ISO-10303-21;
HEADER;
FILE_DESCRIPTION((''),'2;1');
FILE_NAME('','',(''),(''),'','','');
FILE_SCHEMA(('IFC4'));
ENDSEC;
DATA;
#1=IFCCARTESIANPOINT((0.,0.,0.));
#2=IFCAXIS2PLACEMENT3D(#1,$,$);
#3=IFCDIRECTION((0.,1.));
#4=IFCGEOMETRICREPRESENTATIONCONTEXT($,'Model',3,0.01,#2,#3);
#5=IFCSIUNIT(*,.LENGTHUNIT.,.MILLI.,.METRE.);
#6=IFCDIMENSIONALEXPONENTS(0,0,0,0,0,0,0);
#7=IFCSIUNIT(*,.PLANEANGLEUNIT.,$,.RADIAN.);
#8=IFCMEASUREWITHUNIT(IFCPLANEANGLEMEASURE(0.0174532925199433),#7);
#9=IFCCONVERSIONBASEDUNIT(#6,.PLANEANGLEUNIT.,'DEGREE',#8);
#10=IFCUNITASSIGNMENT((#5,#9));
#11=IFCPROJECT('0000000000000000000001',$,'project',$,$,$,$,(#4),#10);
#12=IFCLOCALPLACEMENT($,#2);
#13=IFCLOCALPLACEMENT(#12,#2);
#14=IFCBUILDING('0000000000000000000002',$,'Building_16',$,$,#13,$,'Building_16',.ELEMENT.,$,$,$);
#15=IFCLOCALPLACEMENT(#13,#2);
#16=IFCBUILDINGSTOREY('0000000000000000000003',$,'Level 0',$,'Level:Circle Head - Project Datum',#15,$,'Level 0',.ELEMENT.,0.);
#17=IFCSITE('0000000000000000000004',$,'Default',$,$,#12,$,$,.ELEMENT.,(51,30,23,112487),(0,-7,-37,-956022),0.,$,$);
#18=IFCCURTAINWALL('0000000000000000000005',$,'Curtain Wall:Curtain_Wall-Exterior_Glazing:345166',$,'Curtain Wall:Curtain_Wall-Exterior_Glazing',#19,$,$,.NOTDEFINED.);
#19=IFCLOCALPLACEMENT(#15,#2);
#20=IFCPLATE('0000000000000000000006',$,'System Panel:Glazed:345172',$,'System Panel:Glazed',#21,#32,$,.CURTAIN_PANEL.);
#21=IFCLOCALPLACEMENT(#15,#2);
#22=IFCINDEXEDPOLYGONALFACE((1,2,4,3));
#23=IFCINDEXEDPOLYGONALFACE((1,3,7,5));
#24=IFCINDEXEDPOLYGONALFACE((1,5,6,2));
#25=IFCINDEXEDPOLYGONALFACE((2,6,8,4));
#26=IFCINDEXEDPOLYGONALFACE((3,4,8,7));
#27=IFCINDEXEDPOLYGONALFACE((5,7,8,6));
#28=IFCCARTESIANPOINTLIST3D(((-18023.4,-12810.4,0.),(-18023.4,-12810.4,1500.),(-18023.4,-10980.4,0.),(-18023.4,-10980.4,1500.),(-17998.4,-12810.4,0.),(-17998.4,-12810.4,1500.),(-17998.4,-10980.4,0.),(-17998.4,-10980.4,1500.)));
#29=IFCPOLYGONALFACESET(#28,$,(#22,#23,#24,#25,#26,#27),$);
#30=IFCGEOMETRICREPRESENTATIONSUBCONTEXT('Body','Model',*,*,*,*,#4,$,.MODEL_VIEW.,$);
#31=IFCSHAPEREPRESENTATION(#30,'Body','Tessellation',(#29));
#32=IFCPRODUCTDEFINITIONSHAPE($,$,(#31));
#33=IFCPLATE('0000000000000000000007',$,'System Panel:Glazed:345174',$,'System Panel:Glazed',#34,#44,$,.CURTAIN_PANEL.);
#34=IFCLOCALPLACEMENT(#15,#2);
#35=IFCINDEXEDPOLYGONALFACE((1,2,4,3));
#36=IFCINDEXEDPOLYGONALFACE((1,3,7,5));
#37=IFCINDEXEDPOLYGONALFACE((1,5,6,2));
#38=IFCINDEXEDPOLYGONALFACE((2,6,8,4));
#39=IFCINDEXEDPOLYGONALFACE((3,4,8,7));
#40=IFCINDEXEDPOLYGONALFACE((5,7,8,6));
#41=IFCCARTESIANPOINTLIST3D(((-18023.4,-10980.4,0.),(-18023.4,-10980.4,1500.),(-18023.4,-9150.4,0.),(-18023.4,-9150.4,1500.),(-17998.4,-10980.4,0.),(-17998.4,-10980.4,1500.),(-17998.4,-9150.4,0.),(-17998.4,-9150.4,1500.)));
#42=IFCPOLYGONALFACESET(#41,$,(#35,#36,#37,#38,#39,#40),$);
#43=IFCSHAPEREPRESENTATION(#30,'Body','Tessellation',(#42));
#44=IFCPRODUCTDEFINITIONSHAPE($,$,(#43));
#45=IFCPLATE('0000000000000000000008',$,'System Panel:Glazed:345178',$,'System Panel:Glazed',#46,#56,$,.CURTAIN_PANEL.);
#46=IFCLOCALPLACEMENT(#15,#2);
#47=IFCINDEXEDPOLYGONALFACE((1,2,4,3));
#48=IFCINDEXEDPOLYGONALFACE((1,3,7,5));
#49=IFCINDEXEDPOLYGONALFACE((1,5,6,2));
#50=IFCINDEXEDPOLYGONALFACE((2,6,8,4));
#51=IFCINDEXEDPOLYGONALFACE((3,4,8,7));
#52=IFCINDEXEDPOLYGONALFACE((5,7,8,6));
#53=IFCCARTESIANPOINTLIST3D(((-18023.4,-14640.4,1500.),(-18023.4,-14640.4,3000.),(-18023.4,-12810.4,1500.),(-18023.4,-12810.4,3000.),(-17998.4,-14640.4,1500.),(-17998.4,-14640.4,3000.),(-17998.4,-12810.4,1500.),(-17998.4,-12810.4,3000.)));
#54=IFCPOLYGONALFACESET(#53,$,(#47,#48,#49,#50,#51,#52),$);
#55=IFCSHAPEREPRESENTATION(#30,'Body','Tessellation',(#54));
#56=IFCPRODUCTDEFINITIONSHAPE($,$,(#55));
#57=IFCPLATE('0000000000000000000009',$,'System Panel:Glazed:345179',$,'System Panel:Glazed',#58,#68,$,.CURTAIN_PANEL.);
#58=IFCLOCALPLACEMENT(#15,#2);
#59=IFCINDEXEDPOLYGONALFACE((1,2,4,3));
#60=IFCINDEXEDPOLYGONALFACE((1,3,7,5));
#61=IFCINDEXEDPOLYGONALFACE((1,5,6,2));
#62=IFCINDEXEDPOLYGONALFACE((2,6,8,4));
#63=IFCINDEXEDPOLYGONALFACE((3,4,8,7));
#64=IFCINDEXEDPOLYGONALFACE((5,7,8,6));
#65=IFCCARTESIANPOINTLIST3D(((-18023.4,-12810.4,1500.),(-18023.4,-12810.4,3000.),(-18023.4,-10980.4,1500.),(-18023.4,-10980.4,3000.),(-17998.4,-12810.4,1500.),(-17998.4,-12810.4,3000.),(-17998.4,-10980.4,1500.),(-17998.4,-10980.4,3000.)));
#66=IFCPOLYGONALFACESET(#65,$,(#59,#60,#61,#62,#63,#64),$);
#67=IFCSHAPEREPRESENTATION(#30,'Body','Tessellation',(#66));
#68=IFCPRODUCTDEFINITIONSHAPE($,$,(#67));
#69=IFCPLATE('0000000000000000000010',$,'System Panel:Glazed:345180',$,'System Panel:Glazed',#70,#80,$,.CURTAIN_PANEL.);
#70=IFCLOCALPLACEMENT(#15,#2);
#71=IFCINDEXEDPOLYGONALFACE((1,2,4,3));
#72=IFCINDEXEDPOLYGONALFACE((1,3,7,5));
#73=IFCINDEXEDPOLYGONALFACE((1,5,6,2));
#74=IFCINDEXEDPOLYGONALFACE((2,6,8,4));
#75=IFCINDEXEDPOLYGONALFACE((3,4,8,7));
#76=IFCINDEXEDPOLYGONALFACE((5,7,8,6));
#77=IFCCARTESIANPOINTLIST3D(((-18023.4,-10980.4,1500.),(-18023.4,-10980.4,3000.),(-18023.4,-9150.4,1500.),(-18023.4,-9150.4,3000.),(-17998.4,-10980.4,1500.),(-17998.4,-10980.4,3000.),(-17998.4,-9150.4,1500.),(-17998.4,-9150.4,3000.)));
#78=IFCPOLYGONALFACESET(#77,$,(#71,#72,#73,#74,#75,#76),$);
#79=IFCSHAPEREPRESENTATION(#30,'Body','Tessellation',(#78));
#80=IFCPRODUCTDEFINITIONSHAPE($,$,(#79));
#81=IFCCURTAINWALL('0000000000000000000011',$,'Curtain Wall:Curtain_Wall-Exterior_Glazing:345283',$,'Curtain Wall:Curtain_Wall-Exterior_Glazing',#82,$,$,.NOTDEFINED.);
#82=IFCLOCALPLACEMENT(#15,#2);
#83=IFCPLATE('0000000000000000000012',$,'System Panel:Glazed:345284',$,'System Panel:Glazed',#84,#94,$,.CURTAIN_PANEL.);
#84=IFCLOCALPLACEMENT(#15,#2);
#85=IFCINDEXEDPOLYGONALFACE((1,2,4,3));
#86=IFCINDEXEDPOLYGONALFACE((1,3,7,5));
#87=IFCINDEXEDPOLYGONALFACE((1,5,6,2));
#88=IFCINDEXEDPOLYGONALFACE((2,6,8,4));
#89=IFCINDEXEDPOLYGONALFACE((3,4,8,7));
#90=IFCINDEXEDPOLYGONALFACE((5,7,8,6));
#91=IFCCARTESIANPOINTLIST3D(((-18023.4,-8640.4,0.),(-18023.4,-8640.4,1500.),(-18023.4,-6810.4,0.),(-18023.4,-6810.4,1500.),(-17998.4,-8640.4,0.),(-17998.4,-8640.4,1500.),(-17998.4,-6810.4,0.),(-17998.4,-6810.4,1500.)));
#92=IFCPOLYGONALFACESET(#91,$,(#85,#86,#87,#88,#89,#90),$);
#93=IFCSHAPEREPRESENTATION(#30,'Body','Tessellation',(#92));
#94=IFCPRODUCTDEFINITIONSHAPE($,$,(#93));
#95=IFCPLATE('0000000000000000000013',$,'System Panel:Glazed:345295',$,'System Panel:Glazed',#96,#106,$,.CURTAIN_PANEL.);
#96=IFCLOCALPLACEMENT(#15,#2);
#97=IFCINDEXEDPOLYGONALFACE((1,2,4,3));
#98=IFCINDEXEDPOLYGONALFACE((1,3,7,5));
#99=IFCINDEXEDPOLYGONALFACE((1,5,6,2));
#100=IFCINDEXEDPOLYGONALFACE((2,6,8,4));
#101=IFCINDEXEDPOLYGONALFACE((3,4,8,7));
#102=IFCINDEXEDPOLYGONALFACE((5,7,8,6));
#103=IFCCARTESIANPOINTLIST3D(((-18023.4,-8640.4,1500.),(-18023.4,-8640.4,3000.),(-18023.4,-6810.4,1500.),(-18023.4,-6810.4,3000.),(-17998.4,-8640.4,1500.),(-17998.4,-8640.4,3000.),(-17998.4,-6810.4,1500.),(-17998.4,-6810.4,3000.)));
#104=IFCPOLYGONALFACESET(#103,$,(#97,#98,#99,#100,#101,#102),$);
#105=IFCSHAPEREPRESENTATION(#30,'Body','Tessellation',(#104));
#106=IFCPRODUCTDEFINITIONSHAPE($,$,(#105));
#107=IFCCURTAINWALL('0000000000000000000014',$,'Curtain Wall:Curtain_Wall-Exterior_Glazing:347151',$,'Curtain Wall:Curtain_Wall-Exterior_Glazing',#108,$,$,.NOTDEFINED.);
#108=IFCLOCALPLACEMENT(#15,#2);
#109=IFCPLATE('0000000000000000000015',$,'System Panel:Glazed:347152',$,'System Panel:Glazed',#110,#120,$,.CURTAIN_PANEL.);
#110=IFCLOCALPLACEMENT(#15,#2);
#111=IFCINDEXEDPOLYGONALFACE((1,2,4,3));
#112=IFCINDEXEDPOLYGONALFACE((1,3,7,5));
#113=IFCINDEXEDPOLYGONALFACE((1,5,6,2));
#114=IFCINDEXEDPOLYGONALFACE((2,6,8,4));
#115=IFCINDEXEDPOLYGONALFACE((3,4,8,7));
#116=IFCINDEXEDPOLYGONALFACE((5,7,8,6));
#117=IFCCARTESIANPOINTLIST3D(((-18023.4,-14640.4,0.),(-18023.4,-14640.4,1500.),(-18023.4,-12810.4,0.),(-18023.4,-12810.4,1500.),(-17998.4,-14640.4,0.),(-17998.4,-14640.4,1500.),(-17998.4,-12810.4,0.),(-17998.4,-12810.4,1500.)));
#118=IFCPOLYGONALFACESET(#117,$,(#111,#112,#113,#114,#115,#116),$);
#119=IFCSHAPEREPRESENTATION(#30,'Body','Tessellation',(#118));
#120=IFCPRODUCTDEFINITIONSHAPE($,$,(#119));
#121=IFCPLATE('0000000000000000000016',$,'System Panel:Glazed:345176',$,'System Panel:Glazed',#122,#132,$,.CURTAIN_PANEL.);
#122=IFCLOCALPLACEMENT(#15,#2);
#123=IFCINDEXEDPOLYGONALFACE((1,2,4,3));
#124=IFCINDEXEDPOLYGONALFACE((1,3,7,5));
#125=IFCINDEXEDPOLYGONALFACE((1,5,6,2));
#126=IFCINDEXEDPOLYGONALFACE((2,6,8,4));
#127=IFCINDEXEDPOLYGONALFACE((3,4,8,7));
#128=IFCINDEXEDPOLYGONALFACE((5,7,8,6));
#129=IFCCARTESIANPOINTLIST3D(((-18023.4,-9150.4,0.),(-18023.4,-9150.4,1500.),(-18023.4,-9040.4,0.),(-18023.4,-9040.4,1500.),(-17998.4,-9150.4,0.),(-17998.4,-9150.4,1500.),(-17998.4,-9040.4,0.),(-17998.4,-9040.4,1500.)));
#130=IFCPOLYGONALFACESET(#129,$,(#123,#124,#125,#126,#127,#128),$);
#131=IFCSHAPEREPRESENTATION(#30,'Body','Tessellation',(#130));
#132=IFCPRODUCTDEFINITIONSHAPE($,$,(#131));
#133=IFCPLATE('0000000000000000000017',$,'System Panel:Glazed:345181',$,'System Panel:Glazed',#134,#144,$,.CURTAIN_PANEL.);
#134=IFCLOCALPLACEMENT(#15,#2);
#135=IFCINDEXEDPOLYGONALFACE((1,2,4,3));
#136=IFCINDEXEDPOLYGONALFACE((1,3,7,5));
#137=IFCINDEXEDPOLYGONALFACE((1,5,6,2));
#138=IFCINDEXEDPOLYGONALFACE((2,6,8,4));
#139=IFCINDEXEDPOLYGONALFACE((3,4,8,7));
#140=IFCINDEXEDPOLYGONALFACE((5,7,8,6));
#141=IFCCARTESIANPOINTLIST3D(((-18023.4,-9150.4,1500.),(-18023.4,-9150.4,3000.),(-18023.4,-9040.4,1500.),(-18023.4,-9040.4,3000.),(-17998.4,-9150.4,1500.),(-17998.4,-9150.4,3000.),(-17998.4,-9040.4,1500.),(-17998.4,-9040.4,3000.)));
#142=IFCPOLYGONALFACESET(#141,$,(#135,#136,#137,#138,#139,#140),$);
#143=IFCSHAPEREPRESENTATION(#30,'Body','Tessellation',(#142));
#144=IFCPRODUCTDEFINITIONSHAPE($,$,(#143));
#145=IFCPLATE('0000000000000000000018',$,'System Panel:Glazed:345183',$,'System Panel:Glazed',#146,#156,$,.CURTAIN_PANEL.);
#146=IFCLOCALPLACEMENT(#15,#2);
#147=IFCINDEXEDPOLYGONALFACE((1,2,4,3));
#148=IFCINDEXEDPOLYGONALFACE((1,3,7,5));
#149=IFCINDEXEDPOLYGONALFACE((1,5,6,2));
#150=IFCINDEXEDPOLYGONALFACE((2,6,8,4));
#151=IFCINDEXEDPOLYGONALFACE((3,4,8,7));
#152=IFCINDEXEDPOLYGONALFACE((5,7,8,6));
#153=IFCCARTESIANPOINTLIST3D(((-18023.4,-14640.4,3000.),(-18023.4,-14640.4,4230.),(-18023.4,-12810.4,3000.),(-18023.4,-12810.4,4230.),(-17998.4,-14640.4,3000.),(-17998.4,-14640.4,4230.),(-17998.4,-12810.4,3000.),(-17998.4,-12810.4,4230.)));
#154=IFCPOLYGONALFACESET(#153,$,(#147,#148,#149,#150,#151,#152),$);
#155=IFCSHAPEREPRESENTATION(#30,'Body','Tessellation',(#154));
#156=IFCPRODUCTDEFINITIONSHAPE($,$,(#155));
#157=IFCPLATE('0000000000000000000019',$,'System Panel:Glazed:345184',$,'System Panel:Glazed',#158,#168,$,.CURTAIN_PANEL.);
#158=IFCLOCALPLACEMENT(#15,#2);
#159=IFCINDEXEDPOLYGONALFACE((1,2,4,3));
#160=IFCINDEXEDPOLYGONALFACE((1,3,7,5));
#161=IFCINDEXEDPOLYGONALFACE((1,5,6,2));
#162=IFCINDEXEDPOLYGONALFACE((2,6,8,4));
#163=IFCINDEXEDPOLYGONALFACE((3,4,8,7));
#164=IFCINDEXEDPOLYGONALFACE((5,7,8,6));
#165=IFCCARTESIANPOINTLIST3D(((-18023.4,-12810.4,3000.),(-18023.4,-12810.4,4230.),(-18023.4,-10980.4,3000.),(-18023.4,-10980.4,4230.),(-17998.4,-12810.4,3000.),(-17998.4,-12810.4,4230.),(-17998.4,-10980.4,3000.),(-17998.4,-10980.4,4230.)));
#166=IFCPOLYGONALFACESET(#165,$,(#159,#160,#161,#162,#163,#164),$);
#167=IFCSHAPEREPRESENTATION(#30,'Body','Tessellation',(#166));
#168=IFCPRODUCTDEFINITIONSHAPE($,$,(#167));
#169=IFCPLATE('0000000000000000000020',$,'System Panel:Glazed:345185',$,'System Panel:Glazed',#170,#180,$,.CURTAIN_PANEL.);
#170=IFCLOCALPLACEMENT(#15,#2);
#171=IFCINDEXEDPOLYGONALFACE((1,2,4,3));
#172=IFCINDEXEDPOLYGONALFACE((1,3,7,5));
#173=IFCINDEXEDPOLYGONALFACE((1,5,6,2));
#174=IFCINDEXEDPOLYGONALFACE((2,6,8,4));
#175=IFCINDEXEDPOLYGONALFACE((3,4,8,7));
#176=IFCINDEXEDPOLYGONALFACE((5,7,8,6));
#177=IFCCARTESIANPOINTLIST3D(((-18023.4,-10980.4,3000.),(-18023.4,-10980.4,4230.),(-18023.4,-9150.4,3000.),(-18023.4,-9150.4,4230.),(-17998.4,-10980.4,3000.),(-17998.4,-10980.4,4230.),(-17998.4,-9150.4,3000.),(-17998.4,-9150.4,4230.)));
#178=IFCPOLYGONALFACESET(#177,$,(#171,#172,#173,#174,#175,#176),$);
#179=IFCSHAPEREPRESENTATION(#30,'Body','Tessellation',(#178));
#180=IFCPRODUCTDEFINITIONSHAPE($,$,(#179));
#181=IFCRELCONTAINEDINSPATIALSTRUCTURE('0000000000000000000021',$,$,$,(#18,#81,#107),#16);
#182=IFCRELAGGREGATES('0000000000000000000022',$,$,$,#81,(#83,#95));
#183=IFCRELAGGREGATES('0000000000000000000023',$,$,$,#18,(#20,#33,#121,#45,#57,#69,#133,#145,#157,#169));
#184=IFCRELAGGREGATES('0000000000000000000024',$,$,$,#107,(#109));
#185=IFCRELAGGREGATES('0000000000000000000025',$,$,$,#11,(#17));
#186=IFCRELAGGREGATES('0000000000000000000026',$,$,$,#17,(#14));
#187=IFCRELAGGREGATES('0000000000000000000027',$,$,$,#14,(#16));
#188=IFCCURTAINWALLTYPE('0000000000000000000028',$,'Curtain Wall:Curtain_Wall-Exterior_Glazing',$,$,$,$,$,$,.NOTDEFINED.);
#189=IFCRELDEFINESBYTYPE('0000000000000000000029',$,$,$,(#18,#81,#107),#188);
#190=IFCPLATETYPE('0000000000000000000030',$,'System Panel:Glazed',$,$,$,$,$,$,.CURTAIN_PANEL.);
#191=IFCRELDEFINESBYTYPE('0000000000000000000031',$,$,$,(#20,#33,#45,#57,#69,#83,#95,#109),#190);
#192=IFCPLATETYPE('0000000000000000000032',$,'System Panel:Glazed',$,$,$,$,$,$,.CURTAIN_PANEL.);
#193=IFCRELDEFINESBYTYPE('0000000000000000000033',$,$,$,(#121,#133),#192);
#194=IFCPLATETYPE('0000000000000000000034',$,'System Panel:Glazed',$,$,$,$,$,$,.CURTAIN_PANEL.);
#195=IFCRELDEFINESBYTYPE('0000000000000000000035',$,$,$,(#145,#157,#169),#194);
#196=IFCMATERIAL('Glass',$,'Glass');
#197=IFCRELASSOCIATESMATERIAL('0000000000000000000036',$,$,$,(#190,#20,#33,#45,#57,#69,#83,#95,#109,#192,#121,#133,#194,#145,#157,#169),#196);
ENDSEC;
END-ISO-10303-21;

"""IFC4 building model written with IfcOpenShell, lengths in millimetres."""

from ifc_helpers import new_model, entity, si_unit, converted_unit, direction, frame, origin, place, context, subcontext, project, spatial, indexed_curve, outline, extrude, source, transform, mapped, material, type_object, type_shapes, element, aggregate, save


model = new_model("IFC4")

# Units and contexts
model_context = context("Model", 3, precision=0.01, world=origin(), true_north=direction((0.0, 1.0)))
body_context = subcontext(model_context, "Body", "Model", "MODEL_VIEW")
ifc_project = project(units=[si_unit("LENGTHUNIT", "METRE", prefix="MILLI"), converted_unit("PLANEANGLEUNIT", "DEGREE", entity("IfcPlaneAngleMeasure", 0.0174532925199433), si_unit("PLANEANGLEUNIT", "RADIAN"), dimensions=[0, 0, 0, 0, 0, 0, 0])], contexts=[model_context])

# Site, building, storey
site_placement = place(None, origin())
site = spatial("IfcSite", under=ifc_project, at=site_placement, Name="Default", CompositionType="ELEMENT", RefLatitude=(51, 30, 23, 112487), RefLongitude=(0, -7, -37, -956022), RefElevation=0.0)
building_placement = place(site_placement, origin())
building = spatial("IfcBuilding", under=site, at=building_placement, Name="Building_16", LongName="Building_16", CompositionType="ELEMENT")
storey_placement = place(building_placement, origin())
storey = spatial("IfcBuildingStorey", under=building, at=storey_placement, Name="Level 0", ObjectType="Level:Circle Head - Project Datum", LongName="Level 0", CompositionType="ELEMENT", Elevation=0.0)

# Curtain walls, plates
curtain_wall_type = type_object("IfcCurtainWallType", Name="Curtain Wall:Curtain_Wall-Exterior_Glazing", PredefinedType="NOTDEFINED")
curtain_wall_1_placement = place(storey_placement, origin())
curtain_wall_1 = element("IfcCurtainWall", 1, at=curtain_wall_1_placement, inside=storey, type_object=curtain_wall_type, Name="Curtain Wall:Curtain_Wall-Exterior_Glazing:345166", ObjectType="Curtain Wall:Curtain_Wall-Exterior_Glazing", PredefinedType="NOTDEFINED")
ifc_material_1 = material(Name="Glass", Category="Glass")
plate_type_1 = type_object("IfcPlateType", Name="System Panel:Glazed", PredefinedType="CURTAIN_PANEL", material=ifc_material_1)
shared_shape_1 = source(origin(), body_context, "Body", "SweptSolid", [
    extrude(outline(indexed_curve([(-12.5, -915.0), (12.5, -915.0), (12.5, 915.0), (-12.5, 915.0), (-12.5, -915.0)], self_intersect=False)), frame((0.0, 37.0, 0.0), z_axis=(0.0, 0.0, 1.0), x_axis=(0.0, 1.0, 0.0)), (0.0, 0.0, 1.0), 1500.0),
])
type_shapes(plate_type_1, [shared_shape_1])
plate_1_placement = place(curtain_wall_1_placement, frame((-17973.9, -11895.4, 0.0), z_axis=(0.0, 0.0, 1.0), x_axis=(0.0, 1.0, 0.0)))
plate_1 = element("IfcPlate", 2, at=plate_1_placement, type_object=plate_type_1, material=ifc_material_1, Name="System Panel:Glazed:345172", ObjectType="System Panel:Glazed", PredefinedType="CURTAIN_PANEL", context=body_context, shape_type="MappedRepresentation", body=[
    mapped(shared_shape_1, transform((0.0, 0.0, 0.0), scale=1.0)),
])
plate_2_placement = place(curtain_wall_1_placement, frame((-17973.9, -10065.4, 0.0), z_axis=(0.0, 0.0, 1.0), x_axis=(0.0, 1.0, 0.0)))
plate_2 = element("IfcPlate", 3, at=plate_2_placement, type_object=plate_type_1, material=ifc_material_1, Name="System Panel:Glazed:345174", ObjectType="System Panel:Glazed", PredefinedType="CURTAIN_PANEL", context=body_context, shape_type="MappedRepresentation", body=[
    mapped(shared_shape_1, transform((0.0, 0.0, 0.0), scale=1.0)),
])
plate_3_placement = place(curtain_wall_1_placement, frame((-17973.9, -13725.4, 1500.0), z_axis=(0.0, 0.0, 1.0), x_axis=(0.0, 1.0, 0.0)))
plate_3 = element("IfcPlate", 4, at=plate_3_placement, type_object=plate_type_1, material=ifc_material_1, Name="System Panel:Glazed:345178", ObjectType="System Panel:Glazed", PredefinedType="CURTAIN_PANEL", context=body_context, shape_type="MappedRepresentation", body=[
    mapped(shared_shape_1, transform((0.0, 0.0, 0.0), scale=1.0)),
])
plate_4_placement = place(curtain_wall_1_placement, frame((-17973.9, -11895.4, 1500.0), z_axis=(0.0, 0.0, 1.0), x_axis=(0.0, 1.0, 0.0)))
plate_4 = element("IfcPlate", 5, at=plate_4_placement, type_object=plate_type_1, material=ifc_material_1, Name="System Panel:Glazed:345179", ObjectType="System Panel:Glazed", PredefinedType="CURTAIN_PANEL", context=body_context, shape_type="MappedRepresentation", body=[
    mapped(shared_shape_1, transform((0.0, 0.0, 0.0), scale=1.0)),
])
plate_5_placement = place(curtain_wall_1_placement, frame((-17973.9, -10065.4, 1500.0), z_axis=(0.0, 0.0, 1.0), x_axis=(0.0, 1.0, 0.0)))
plate_5 = element("IfcPlate", 6, at=plate_5_placement, type_object=plate_type_1, material=ifc_material_1, Name="System Panel:Glazed:345180", ObjectType="System Panel:Glazed", PredefinedType="CURTAIN_PANEL", context=body_context, shape_type="MappedRepresentation", body=[
    mapped(shared_shape_1, transform((0.0, 0.0, 0.0), scale=1.0)),
])
curtain_wall_2_placement = place(storey_placement, origin())
curtain_wall_2 = element("IfcCurtainWall", 7, at=curtain_wall_2_placement, inside=storey, type_object=curtain_wall_type, Name="Curtain Wall:Curtain_Wall-Exterior_Glazing:345283", ObjectType="Curtain Wall:Curtain_Wall-Exterior_Glazing", PredefinedType="NOTDEFINED")
plate_6_placement = place(curtain_wall_2_placement, frame((-17973.9, -7725.4, 0.0), z_axis=(0.0, 0.0, 1.0), x_axis=(0.0, 1.0, 0.0)))
plate_6 = element("IfcPlate", 8, at=plate_6_placement, type_object=plate_type_1, material=ifc_material_1, Name="System Panel:Glazed:345284", ObjectType="System Panel:Glazed", PredefinedType="CURTAIN_PANEL", context=body_context, shape_type="MappedRepresentation", body=[
    mapped(shared_shape_1, transform((0.0, 0.0, 0.0), scale=1.0)),
])
plate_7_placement = place(curtain_wall_2_placement, frame((-17973.9, -7725.4, 1500.0), z_axis=(0.0, 0.0, 1.0), x_axis=(0.0, 1.0, 0.0)))
plate_7 = element("IfcPlate", 9, at=plate_7_placement, type_object=plate_type_1, material=ifc_material_1, Name="System Panel:Glazed:345295", ObjectType="System Panel:Glazed", PredefinedType="CURTAIN_PANEL", context=body_context, shape_type="MappedRepresentation", body=[
    mapped(shared_shape_1, transform((0.0, 0.0, 0.0), scale=1.0)),
])
curtain_wall_3_placement = place(storey_placement, origin())
curtain_wall_3 = element("IfcCurtainWall", 10, at=curtain_wall_3_placement, inside=storey, type_object=curtain_wall_type, Name="Curtain Wall:Curtain_Wall-Exterior_Glazing:347151", ObjectType="Curtain Wall:Curtain_Wall-Exterior_Glazing", PredefinedType="NOTDEFINED")
plate_8_placement = place(curtain_wall_3_placement, frame((-17973.9, -13725.4, 0.0), z_axis=(0.0, 0.0, 1.0), x_axis=(0.0, 1.0, 0.0)))
plate_8 = element("IfcPlate", 11, at=plate_8_placement, type_object=plate_type_1, material=ifc_material_1, Name="System Panel:Glazed:347152", ObjectType="System Panel:Glazed", PredefinedType="CURTAIN_PANEL", context=body_context, shape_type="MappedRepresentation", body=[
    mapped(shared_shape_1, transform((0.0, 0.0, 0.0), scale=1.0)),
])

# Plates
plate_type_2 = type_object("IfcPlateType", Name="System Panel:Glazed", PredefinedType="CURTAIN_PANEL", material=ifc_material_1)
shared_shape_2 = source(origin(), body_context, "Body", "SweptSolid", [
    extrude(outline(indexed_curve([(-12.5, -55.0), (12.5, -55.0), (12.5, 55.0), (-12.5, 55.0), (-12.5, -55.0)], self_intersect=False)), frame((0.0, 37.0, 0.0), z_axis=(0.0, 0.0, 1.0), x_axis=(0.0, 1.0, 0.0)), (0.0, 0.0, 1.0), 1500.0),
])
type_shapes(plate_type_2, [shared_shape_2])
plate_9_placement = place(curtain_wall_1_placement, frame((-17973.9, -9095.4, 0.0), z_axis=(0.0, 0.0, 1.0), x_axis=(0.0, 1.0, 0.0)))
plate_9 = element("IfcPlate", 12, at=plate_9_placement, type_object=plate_type_2, material=ifc_material_1, Name="System Panel:Glazed:345176", ObjectType="System Panel:Glazed", PredefinedType="CURTAIN_PANEL", context=body_context, shape_type="MappedRepresentation", body=[
    mapped(shared_shape_2, transform((0.0, 0.0, 0.0), scale=1.0)),
])
plate_10_placement = place(curtain_wall_1_placement, frame((-17973.9, -9095.4, 1500.0), z_axis=(0.0, 0.0, 1.0), x_axis=(0.0, 1.0, 0.0)))
plate_10 = element("IfcPlate", 13, at=plate_10_placement, type_object=plate_type_2, material=ifc_material_1, Name="System Panel:Glazed:345181", ObjectType="System Panel:Glazed", PredefinedType="CURTAIN_PANEL", context=body_context, shape_type="MappedRepresentation", body=[
    mapped(shared_shape_2, transform((0.0, 0.0, 0.0), scale=1.0)),
])
plate_type_3 = type_object("IfcPlateType", Name="System Panel:Glazed", PredefinedType="CURTAIN_PANEL", material=ifc_material_1)
shared_shape_3 = source(origin(), body_context, "Body", "SweptSolid", [
    extrude(outline(indexed_curve([(-12.5, -915.0), (12.5, -915.0), (12.5, 915.0), (-12.5, 915.0), (-12.5, -915.0)], self_intersect=False)), frame((0.0, 37.0, 0.0), z_axis=(0.0, 0.0, 1.0), x_axis=(0.0, 1.0, 0.0)), (0.0, 0.0, 1.0), 1230.0),
])
type_shapes(plate_type_3, [shared_shape_3])
plate_11_placement = place(curtain_wall_1_placement, frame((-17973.9, -13725.4, 3000.0), z_axis=(0.0, 0.0, 1.0), x_axis=(0.0, 1.0, 0.0)))
plate_11 = element("IfcPlate", 14, at=plate_11_placement, type_object=plate_type_3, material=ifc_material_1, Name="System Panel:Glazed:345183", ObjectType="System Panel:Glazed", PredefinedType="CURTAIN_PANEL", context=body_context, shape_type="MappedRepresentation", body=[
    mapped(shared_shape_3, transform((0.0, 0.0, 0.0), scale=1.0)),
])
plate_12_placement = place(curtain_wall_1_placement, frame((-17973.9, -11895.4, 3000.0), z_axis=(0.0, 0.0, 1.0), x_axis=(0.0, 1.0, 0.0)))
plate_12 = element("IfcPlate", 15, at=plate_12_placement, type_object=plate_type_3, material=ifc_material_1, Name="System Panel:Glazed:345184", ObjectType="System Panel:Glazed", PredefinedType="CURTAIN_PANEL", context=body_context, shape_type="MappedRepresentation", body=[
    mapped(shared_shape_3, transform((0.0, 0.0, 0.0), scale=1.0)),
])
plate_13_placement = place(curtain_wall_1_placement, frame((-17973.9, -10065.4, 3000.0), z_axis=(0.0, 0.0, 1.0), x_axis=(0.0, 1.0, 0.0)))
plate_13 = element("IfcPlate", 16, at=plate_13_placement, type_object=plate_type_3, material=ifc_material_1, Name="System Panel:Glazed:345185", ObjectType="System Panel:Glazed", PredefinedType="CURTAIN_PANEL", context=body_context, shape_type="MappedRepresentation", body=[
    mapped(shared_shape_3, transform((0.0, 0.0, 0.0), scale=1.0)),
])
aggregate(curtain_wall_2, [plate_6, plate_7])
aggregate(curtain_wall_1, [plate_1, plate_2, plate_9, plate_3, plate_4, plate_5, plate_10, plate_11, plate_12, plate_13])
aggregate(curtain_wall_3, [plate_8])

save(model, "model.ifc")
